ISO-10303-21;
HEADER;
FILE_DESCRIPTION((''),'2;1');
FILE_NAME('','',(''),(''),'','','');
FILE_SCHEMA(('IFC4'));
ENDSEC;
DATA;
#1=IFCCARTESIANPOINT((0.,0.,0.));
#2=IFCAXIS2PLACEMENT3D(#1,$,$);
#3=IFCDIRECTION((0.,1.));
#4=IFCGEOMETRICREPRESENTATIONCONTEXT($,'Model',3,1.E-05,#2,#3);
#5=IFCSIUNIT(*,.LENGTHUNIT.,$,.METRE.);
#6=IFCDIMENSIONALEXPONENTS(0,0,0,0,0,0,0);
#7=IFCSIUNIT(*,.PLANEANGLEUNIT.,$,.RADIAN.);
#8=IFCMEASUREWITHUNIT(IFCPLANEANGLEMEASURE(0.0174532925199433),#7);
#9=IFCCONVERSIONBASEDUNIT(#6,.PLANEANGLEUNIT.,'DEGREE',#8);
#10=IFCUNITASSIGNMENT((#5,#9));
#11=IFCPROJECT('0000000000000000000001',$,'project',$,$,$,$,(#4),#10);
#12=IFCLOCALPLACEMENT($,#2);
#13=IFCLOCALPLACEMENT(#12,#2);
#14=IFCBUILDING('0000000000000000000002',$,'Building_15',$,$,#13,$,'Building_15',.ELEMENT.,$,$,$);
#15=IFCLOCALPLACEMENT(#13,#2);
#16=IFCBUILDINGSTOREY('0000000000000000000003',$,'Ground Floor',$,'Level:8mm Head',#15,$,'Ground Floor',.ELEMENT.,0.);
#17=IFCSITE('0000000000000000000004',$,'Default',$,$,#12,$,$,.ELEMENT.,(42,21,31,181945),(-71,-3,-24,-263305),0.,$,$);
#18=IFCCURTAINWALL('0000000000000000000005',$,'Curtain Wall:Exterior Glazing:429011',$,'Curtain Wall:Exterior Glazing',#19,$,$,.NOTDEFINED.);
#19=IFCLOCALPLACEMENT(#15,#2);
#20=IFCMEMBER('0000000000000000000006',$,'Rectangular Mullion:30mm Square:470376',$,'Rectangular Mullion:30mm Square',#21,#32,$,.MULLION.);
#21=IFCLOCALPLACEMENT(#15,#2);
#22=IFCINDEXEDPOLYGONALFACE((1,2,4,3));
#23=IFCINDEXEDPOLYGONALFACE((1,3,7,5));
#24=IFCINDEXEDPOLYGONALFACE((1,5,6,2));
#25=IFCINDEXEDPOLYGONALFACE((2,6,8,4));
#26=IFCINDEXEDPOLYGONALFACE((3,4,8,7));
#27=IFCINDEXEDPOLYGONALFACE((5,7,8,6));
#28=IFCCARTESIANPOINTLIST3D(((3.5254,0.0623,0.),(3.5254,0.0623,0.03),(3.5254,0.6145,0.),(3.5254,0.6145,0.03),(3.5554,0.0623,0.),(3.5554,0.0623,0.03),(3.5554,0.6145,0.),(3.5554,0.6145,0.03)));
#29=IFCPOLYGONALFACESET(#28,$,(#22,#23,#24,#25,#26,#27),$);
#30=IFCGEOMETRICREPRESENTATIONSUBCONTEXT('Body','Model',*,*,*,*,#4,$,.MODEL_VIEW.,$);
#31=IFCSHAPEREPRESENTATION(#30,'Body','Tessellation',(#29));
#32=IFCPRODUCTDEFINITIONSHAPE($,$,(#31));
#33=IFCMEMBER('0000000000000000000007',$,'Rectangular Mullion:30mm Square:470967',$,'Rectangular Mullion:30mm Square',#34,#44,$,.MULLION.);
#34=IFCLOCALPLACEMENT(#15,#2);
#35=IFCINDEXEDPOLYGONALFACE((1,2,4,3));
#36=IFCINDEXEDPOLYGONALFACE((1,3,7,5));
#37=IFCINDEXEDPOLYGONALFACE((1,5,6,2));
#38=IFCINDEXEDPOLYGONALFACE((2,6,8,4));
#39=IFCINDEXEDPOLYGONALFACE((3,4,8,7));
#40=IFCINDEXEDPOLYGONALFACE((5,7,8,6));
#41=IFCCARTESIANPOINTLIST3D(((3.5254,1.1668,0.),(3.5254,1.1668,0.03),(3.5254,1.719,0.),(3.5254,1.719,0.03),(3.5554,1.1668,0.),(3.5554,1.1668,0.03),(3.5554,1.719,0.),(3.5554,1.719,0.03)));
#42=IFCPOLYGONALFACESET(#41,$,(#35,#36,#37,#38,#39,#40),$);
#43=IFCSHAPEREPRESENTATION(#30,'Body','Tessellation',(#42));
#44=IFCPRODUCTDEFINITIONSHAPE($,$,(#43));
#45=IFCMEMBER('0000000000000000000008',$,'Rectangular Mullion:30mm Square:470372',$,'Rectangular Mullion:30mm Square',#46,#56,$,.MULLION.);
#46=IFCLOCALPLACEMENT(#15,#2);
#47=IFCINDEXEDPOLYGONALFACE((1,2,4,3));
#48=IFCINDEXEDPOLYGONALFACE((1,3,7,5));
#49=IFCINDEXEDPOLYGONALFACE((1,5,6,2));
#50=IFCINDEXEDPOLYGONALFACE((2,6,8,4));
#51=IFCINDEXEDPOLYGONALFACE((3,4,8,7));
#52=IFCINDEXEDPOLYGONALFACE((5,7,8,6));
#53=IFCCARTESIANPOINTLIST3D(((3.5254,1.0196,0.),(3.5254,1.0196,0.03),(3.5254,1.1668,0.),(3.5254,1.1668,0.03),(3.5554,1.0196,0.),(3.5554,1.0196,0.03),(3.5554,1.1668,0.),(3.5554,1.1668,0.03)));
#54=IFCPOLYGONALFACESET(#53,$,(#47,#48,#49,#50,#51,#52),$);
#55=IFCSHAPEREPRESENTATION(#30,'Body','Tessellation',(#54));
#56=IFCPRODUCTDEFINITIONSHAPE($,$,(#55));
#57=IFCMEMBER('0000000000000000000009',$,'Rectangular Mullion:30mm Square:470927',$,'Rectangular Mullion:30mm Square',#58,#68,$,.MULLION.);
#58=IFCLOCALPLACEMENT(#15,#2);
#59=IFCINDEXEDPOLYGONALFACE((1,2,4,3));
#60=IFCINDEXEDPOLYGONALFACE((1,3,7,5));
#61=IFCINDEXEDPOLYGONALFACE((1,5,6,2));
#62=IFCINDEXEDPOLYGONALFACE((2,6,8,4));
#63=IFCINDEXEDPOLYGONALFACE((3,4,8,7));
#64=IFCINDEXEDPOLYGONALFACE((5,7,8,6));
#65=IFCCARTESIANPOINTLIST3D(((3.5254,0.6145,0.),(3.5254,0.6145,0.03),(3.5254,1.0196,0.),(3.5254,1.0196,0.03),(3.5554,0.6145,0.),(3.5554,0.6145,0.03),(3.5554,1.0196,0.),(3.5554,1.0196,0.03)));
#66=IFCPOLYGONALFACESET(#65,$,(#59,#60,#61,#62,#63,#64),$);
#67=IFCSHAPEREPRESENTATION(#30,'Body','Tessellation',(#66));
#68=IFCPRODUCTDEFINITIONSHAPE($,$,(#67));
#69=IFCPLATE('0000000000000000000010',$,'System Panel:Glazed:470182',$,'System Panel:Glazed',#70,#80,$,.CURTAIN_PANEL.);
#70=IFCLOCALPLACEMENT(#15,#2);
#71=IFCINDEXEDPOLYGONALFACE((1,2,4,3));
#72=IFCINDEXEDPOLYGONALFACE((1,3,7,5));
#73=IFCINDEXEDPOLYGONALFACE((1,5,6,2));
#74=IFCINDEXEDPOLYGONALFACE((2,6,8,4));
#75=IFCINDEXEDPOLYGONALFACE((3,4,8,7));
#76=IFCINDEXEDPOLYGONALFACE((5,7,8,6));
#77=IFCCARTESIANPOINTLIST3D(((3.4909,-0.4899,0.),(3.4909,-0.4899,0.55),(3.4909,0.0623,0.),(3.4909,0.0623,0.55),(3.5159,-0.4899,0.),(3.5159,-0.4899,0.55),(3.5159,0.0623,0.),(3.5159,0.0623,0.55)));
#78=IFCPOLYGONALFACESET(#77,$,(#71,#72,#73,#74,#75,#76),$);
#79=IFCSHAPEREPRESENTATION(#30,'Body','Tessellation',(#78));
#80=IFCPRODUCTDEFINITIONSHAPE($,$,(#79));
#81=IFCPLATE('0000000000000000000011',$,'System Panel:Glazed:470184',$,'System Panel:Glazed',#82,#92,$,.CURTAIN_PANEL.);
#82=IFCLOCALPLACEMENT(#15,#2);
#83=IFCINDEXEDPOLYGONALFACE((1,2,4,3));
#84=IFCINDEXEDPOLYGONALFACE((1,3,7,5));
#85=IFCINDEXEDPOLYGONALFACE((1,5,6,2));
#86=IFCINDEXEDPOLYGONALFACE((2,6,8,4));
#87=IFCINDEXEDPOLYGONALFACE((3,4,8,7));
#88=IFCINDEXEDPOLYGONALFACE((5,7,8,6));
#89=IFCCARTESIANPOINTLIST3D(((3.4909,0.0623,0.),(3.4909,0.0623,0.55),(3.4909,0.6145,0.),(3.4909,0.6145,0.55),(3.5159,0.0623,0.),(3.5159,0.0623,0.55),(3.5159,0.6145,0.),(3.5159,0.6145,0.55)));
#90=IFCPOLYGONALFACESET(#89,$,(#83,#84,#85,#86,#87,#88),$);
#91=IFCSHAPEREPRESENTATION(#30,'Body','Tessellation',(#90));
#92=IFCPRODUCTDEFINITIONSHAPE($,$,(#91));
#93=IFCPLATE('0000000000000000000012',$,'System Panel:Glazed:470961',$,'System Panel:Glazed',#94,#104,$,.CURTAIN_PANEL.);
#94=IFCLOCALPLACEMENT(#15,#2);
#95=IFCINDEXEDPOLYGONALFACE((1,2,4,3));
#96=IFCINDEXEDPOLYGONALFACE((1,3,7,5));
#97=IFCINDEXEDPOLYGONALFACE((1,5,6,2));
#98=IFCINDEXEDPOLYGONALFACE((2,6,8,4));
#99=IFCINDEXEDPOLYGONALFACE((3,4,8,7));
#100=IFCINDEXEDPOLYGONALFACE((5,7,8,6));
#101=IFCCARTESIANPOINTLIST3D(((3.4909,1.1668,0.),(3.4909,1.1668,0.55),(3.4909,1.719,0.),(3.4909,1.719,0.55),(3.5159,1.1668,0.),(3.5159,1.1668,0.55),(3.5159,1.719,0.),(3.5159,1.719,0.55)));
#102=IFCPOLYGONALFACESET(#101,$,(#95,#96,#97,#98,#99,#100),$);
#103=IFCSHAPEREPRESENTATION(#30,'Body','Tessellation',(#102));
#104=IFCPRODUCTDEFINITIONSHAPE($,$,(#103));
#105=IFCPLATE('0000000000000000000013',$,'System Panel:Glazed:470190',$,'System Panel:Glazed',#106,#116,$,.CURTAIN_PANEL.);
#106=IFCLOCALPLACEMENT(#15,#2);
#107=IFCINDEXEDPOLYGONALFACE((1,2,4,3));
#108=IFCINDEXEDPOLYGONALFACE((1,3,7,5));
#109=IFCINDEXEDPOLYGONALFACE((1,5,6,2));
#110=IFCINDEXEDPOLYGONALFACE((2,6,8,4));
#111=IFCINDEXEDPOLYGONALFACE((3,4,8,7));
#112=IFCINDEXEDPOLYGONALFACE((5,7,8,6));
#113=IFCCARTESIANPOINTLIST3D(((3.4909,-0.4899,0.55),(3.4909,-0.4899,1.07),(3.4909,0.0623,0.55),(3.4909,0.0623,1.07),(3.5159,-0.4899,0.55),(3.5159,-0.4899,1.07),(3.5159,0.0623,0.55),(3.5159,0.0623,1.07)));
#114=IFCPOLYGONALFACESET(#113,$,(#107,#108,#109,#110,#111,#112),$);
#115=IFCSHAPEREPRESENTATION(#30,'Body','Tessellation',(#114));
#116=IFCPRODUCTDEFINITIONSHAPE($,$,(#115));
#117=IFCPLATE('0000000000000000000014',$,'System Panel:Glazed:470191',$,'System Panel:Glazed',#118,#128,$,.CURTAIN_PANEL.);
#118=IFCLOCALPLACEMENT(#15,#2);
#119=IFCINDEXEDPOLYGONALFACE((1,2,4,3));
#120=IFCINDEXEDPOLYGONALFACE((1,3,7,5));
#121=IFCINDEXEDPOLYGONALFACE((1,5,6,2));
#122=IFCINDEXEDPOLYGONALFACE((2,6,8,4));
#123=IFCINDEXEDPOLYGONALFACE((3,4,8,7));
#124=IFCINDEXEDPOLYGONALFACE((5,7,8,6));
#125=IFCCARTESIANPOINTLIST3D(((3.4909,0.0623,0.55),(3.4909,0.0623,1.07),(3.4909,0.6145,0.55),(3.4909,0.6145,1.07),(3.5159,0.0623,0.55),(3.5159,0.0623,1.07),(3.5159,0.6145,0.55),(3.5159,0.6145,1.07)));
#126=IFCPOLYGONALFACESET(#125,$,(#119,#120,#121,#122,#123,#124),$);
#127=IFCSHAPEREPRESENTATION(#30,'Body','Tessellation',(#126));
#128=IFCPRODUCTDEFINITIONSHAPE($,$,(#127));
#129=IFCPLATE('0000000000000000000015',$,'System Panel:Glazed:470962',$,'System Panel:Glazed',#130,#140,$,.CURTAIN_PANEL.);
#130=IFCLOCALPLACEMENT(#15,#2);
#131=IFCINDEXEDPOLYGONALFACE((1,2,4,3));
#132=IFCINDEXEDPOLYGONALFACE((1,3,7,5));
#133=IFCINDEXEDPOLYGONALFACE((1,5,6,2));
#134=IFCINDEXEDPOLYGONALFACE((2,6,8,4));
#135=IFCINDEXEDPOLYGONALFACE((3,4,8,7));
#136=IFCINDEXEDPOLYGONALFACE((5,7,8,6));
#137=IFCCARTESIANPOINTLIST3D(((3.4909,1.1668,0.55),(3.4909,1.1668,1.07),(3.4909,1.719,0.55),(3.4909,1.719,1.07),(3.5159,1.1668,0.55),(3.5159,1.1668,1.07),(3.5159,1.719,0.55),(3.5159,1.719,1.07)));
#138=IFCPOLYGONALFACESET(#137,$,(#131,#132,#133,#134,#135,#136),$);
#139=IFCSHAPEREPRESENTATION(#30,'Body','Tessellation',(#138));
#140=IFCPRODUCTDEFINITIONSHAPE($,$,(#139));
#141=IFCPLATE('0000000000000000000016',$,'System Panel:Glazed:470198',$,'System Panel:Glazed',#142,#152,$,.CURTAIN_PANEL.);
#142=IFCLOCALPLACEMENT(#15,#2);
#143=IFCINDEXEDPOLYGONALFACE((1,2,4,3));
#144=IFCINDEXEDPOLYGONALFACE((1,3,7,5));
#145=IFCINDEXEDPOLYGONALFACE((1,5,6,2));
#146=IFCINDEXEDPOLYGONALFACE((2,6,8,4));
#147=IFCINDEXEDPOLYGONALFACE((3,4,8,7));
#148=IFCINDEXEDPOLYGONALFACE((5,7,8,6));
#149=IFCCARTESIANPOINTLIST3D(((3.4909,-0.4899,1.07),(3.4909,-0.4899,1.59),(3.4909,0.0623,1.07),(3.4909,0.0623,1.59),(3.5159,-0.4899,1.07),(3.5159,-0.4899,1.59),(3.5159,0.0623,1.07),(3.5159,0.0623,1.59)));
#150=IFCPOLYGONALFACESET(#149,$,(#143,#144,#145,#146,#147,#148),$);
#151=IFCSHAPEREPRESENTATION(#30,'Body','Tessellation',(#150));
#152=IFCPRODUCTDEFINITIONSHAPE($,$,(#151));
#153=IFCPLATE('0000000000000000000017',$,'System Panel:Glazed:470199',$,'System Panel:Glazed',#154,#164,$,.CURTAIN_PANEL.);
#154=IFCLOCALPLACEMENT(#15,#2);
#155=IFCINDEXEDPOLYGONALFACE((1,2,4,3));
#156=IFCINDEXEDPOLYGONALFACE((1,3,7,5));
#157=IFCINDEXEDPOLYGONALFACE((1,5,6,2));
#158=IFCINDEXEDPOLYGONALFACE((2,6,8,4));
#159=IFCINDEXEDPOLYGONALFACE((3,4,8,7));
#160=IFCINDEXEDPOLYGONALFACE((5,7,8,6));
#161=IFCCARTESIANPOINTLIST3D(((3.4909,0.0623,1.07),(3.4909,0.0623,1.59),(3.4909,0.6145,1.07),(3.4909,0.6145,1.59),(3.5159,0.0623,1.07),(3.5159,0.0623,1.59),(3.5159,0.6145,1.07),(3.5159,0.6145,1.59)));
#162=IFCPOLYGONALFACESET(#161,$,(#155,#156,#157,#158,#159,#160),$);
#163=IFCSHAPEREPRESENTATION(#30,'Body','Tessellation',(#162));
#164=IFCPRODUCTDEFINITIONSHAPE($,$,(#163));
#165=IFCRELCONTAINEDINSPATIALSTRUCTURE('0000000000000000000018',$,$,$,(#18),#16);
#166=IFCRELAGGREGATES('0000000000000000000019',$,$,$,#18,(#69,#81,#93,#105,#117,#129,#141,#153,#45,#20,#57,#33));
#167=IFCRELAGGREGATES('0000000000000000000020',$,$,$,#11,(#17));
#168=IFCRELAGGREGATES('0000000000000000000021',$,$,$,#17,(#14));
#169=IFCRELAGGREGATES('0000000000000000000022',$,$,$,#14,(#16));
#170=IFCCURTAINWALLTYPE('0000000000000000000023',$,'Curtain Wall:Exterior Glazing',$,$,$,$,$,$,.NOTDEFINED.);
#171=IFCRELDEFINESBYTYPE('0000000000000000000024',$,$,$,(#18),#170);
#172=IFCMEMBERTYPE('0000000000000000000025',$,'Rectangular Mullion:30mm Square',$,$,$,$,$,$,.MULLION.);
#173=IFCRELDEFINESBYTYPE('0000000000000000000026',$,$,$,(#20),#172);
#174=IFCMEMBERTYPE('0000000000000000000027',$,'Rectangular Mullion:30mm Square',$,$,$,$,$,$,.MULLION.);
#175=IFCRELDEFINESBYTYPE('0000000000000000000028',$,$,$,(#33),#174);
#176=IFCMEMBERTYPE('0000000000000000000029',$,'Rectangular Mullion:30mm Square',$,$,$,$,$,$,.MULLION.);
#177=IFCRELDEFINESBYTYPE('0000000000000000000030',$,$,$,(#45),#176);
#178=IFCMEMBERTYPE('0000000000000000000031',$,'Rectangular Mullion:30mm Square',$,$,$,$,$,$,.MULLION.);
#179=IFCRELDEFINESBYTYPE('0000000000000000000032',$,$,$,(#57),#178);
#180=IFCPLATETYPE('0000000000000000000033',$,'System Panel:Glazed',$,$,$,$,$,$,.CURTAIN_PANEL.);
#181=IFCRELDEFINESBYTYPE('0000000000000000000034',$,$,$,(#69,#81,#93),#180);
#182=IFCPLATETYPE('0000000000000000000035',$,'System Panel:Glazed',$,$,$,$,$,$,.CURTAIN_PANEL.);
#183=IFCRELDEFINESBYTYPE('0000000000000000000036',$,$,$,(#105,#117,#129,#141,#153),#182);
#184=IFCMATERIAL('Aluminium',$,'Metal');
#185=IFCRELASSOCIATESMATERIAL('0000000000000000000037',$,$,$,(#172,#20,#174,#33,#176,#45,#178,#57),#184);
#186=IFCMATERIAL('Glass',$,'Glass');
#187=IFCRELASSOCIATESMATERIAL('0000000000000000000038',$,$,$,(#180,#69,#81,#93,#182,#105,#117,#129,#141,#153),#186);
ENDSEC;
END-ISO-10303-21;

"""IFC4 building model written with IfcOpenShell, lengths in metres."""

from ifc_helpers import new_model, entity, si_unit, converted_unit, direction, frame, origin, place, context, subcontext, project, spatial, indexed_curve, outline, extrude, source, transform, mapped, material, type_object, type_shapes, element, aggregate, save


model = new_model("IFC4")

# Units and contexts
model_context = context("Model", 3, precision=1e-05, world=origin(), true_north=direction((0.0, 1.0)))
body_context = subcontext(model_context, "Body", "Model", "MODEL_VIEW")
ifc_project = project(units=[si_unit("LENGTHUNIT", "METRE"), converted_unit("PLANEANGLEUNIT", "DEGREE", entity("IfcPlaneAngleMeasure", 0.0174532925199433), si_unit("PLANEANGLEUNIT", "RADIAN"), dimensions=[0, 0, 0, 0, 0, 0, 0])], contexts=[model_context])

# Site, building, storey
site_placement = place(None, origin())
site = spatial("IfcSite", under=ifc_project, at=site_placement, Name="Default", CompositionType="ELEMENT", RefLatitude=(42, 21, 31, 181945), RefLongitude=(-71, -3, -24, -263305), RefElevation=0.0)
building_placement = place(site_placement, origin())
building = spatial("IfcBuilding", under=site, at=building_placement, Name="Building_15", LongName="Building_15", CompositionType="ELEMENT")
storey_placement = place(building_placement, origin())
storey = spatial("IfcBuildingStorey", under=building, at=storey_placement, Name="Ground Floor", ObjectType="Level:8mm Head", LongName="Ground Floor", CompositionType="ELEMENT", Elevation=0.0)

# Curtain wall, members, plates
curtain_wall_type = type_object("IfcCurtainWallType", Name="Curtain Wall:Exterior Glazing", PredefinedType="NOTDEFINED")
curtain_wall_placement = place(storey_placement, origin())
curtain_wall = element("IfcCurtainWall", 1, at=curtain_wall_placement, inside=storey, type_object=curtain_wall_type, Name="Curtain Wall:Exterior Glazing:429011", ObjectType="Curtain Wall:Exterior Glazing", PredefinedType="NOTDEFINED")
ifc_material_1 = material(Name="Aluminium", Category="Metal")
member_type_1 = type_object("IfcMemberType", Name="Rectangular Mullion:30mm Square", PredefinedType="MULLION", material=ifc_material_1)
shared_shape_1 = source(origin(), body_context, "Body", "SweptSolid", [
    extrude(outline(indexed_curve([(-0.015, -0.015), (0.015, -0.015), (0.015, 0.015), (-0.015, 0.015), (-0.015, -0.015)], self_intersect=False)), frame((-0.015, 0.0, -0.5522), z_axis=(0.0, 0.0, 1.0), x_axis=(-1.0, 0.0, 0.0)), (0.0, 0.0, 1.0), 0.5522),
])
type_shapes(member_type_1, [shared_shape_1])
member_1_placement = place(curtain_wall_placement, frame((3.5404, 0.0623, 0.0), z_axis=(0.0, -1.0, 0.0), x_axis=(0.0, 0.0, -1.0)))
member_1 = element("IfcMember", 2, at=member_1_placement, type_object=member_type_1, material=ifc_material_1, Name="Rectangular Mullion:30mm Square:470376", ObjectType="Rectangular Mullion:30mm Square", PredefinedType="MULLION", context=body_context, shape_type="MappedRepresentation", body=[
    mapped(shared_shape_1, transform((0.0, 0.0, 0.0), scale=1.0)),
])
member_type_2 = type_object("IfcMemberType", Name="Rectangular Mullion:30mm Square", PredefinedType="MULLION", material=ifc_material_1)
shared_shape_2 = source(origin(), body_context, "Body", "SweptSolid", [
    extrude(outline(indexed_curve([(-0.015, -0.015), (0.015, -0.015), (0.015, 0.015), (-0.015, 0.015), (-0.015, -0.015)], self_intersect=False)), frame((-0.015, 0.0, -0.5522), z_axis=(0.0, 0.0, 1.0), x_axis=(-1.0, 0.0, 0.0)), (0.0, 0.0, 1.0), 0.5522),
])
type_shapes(member_type_2, [shared_shape_2])
member_2_placement = place(curtain_wall_placement, frame((3.5404, 1.1668, 0.0), z_axis=(0.0, -1.0, 0.0), x_axis=(0.0, 0.0, -1.0)))
member_2 = element("IfcMember", 3, at=member_2_placement, type_object=member_type_2, material=ifc_material_1, Name="Rectangular Mullion:30mm Square:470967", ObjectType="Rectangular Mullion:30mm Square", PredefinedType="MULLION", context=body_context, shape_type="MappedRepresentation", body=[
    mapped(shared_shape_2, transform((0.0, 0.0, 0.0), scale=1.0)),
])
member_type_3 = type_object("IfcMemberType", Name="Rectangular Mullion:30mm Square", PredefinedType="MULLION", material=ifc_material_1)
shared_shape_3 = source(origin(), body_context, "Body", "SweptSolid", [
    extrude(outline(indexed_curve([(-0.015, -0.015), (0.015, -0.015), (0.015, 0.015), (-0.015, 0.015), (-0.015, -0.015)], self_intersect=False)), frame((-0.015, 0.0, -0.1472), z_axis=(0.0, 0.0, 1.0), x_axis=(-1.0, 0.0, 0.0)), (0.0, 0.0, 1.0), 0.1472),
])
type_shapes(member_type_3, [shared_shape_3])
member_3_placement = place(curtain_wall_placement, frame((3.5404, 1.0196, 0.0), z_axis=(0.0, -1.0, 0.0), x_axis=(0.0, 0.0, -1.0)))
member_3 = element("IfcMember", 4, at=member_3_placement, type_object=member_type_3, material=ifc_material_1, Name="Rectangular Mullion:30mm Square:470372", ObjectType="Rectangular Mullion:30mm Square", PredefinedType="MULLION", context=body_context, shape_type="MappedRepresentation", body=[
    mapped(shared_shape_3, transform((0.0, 0.0, 0.0), scale=1.0)),
])
member_type_4 = type_object("IfcMemberType", Name="Rectangular Mullion:30mm Square", PredefinedType="MULLION", material=ifc_material_1)
shared_shape_4 = source(origin(), body_context, "Body", "SweptSolid", [
    extrude(outline(indexed_curve([(-0.015, -0.015), (0.015, -0.015), (0.015, 0.015), (-0.015, 0.015), (-0.015, -0.015)], self_intersect=False)), frame((-0.015, 0.0, -0.405), z_axis=(0.0, 0.0, 1.0), x_axis=(-1.0, 0.0, 0.0)), (0.0, 0.0, 1.0), 0.405),
])
type_shapes(member_type_4, [shared_shape_4])
member_4_placement = place(curtain_wall_placement, frame((3.5404, 0.6145, 0.0), z_axis=(0.0, -1.0, 0.0), x_axis=(0.0, 0.0, -1.0)))
member_4 = element("IfcMember", 5, at=member_4_placement, type_object=member_type_4, material=ifc_material_1, Name="Rectangular Mullion:30mm Square:470927", ObjectType="Rectangular Mullion:30mm Square", PredefinedType="MULLION", context=body_context, shape_type="MappedRepresentation", body=[
    mapped(shared_shape_4, transform((0.0, 0.0, 0.0), scale=1.0)),
])
ifc_material_2 = material(Name="Glass", Category="Glass")
plate_type_1 = type_object("IfcPlateType", Name="System Panel:Glazed", PredefinedType="CURTAIN_PANEL", material=ifc_material_2)
shared_shape_5 = source(origin(), body_context, "Body", "SweptSolid", [
    extrude(outline(indexed_curve([(-0.0125, -0.2761), (0.0125, -0.2761), (0.0125, 0.2761), (-0.0125, 0.2761), (-0.0125, -0.2761)], self_intersect=False)), frame((0.0, 0.037, 0.0), z_axis=(0.0, 0.0, 1.0), x_axis=(0.0, 1.0, 0.0)), (0.0, 0.0, 1.0), 0.55),
])
type_shapes(plate_type_1, [shared_shape_5])
plate_1_placement = place(curtain_wall_placement, frame((3.5404, -0.2138, 0.0), z_axis=(0.0, 0.0, 1.0), x_axis=(0.0, 1.0, 0.0)))
plate_1 = element("IfcPlate", 6, at=plate_1_placement, type_object=plate_type_1, material=ifc_material_2, Name="System Panel:Glazed:470182", ObjectType="System Panel:Glazed", PredefinedType="CURTAIN_PANEL", context=body_context, shape_type="MappedRepresentation", body=[
    mapped(shared_shape_5, transform((0.0, 0.0, 0.0), scale=1.0)),
])
plate_2_placement = place(curtain_wall_placement, frame((3.5404, 0.3384, 0.0), z_axis=(0.0, 0.0, 1.0), x_axis=(0.0, 1.0, 0.0)))
plate_2 = element("IfcPlate", 7, at=plate_2_placement, type_object=plate_type_1, material=ifc_material_2, Name="System Panel:Glazed:470184", ObjectType="System Panel:Glazed", PredefinedType="CURTAIN_PANEL", context=body_context, shape_type="MappedRepresentation", body=[
    mapped(shared_shape_5, transform((0.0, 0.0, 0.0), scale=1.0)),
])
plate_3_placement = place(curtain_wall_placement, frame((3.5404, 1.4429, 0.0), z_axis=(0.0, 0.0, 1.0), x_axis=(0.0, 1.0, 0.0)))
plate_3 = element("IfcPlate", 8, at=plate_3_placement, type_object=plate_type_1, material=ifc_material_2, Name="System Panel:Glazed:470961", ObjectType="System Panel:Glazed", PredefinedType="CURTAIN_PANEL", context=body_context, shape_type="MappedRepresentation", body=[
    mapped(shared_shape_5, transform((0.0, 0.0, 0.0), scale=1.0)),
])
plate_type_2 = type_object("IfcPlateType", Name="System Panel:Glazed", PredefinedType="CURTAIN_PANEL", material=ifc_material_2)
shared_shape_6 = source(origin(), body_context, "Body", "SweptSolid", [
    extrude(outline(indexed_curve([(-0.0125, -0.2761), (0.0125, -0.2761), (0.0125, 0.2761), (-0.0125, 0.2761), (-0.0125, -0.2761)], self_intersect=False)), frame((0.0, 0.037, 0.0), z_axis=(0.0, 0.0, 1.0), x_axis=(0.0, 1.0, 0.0)), (0.0, 0.0, 1.0), 0.52),
])
type_shapes(plate_type_2, [shared_shape_6])
plate_4_placement = place(curtain_wall_placement, frame((3.5404, -0.2138, 0.55), z_axis=(0.0, 0.0, 1.0), x_axis=(0.0, 1.0, 0.0)))
plate_4 = element("IfcPlate", 9, at=plate_4_placement, type_object=plate_type_2, material=ifc_material_2, Name="System Panel:Glazed:470190", ObjectType="System Panel:Glazed", PredefinedType="CURTAIN_PANEL", context=body_context, shape_type="MappedRepresentation", body=[
    mapped(shared_shape_6, transform((0.0, 0.0, 0.0), scale=1.0)),
])
plate_5_placement = place(curtain_wall_placement, frame((3.5404, 0.3384, 0.55), z_axis=(0.0, 0.0, 1.0), x_axis=(0.0, 1.0, 0.0)))
plate_5 = element("IfcPlate", 10, at=plate_5_placement, type_object=plate_type_2, material=ifc_material_2, Name="System Panel:Glazed:470191", ObjectType="System Panel:Glazed", PredefinedType="CURTAIN_PANEL", context=body_context, shape_type="MappedRepresentation", body=[
    mapped(shared_shape_6, transform((0.0, 0.0, 0.0), scale=1.0)),
])
plate_6_placement = place(curtain_wall_placement, frame((3.5404, 1.4429, 0.55), z_axis=(0.0, 0.0, 1.0), x_axis=(0.0, 1.0, 0.0)))
plate_6 = element("IfcPlate", 11, at=plate_6_placement, type_object=plate_type_2, material=ifc_material_2, Name="System Panel:Glazed:470962", ObjectType="System Panel:Glazed", PredefinedType="CURTAIN_PANEL", context=body_context, shape_type="MappedRepresentation", body=[
    mapped(shared_shape_6, transform((0.0, 0.0, 0.0), scale=1.0)),
])
plate_7_placement = place(curtain_wall_placement, frame((3.5404, -0.2138, 1.07), z_axis=(0.0, 0.0, 1.0), x_axis=(0.0, 1.0, 0.0)))
plate_7 = element("IfcPlate", 12, at=plate_7_placement, type_object=plate_type_2, material=ifc_material_2, Name="System Panel:Glazed:470198", ObjectType="System Panel:Glazed", PredefinedType="CURTAIN_PANEL", context=body_context, shape_type="MappedRepresentation", body=[
    mapped(shared_shape_6, transform((0.0, 0.0, 0.0), scale=1.0)),
])
plate_8_placement = place(curtain_wall_placement, frame((3.5404, 0.3384, 1.07), z_axis=(0.0, 0.0, 1.0), x_axis=(0.0, 1.0, 0.0)))
plate_8 = element("IfcPlate", 13, at=plate_8_placement, type_object=plate_type_2, material=ifc_material_2, Name="System Panel:Glazed:470199", ObjectType="System Panel:Glazed", PredefinedType="CURTAIN_PANEL", context=body_context, shape_type="MappedRepresentation", body=[
    mapped(shared_shape_6, transform((0.0, 0.0, 0.0), scale=1.0)),
])
aggregate(curtain_wall, [plate_1, plate_2, plate_3, plate_4, plate_5, plate_6, plate_7, plate_8, member_3, member_1, member_4, member_2])

save(model, "model.ifc")
